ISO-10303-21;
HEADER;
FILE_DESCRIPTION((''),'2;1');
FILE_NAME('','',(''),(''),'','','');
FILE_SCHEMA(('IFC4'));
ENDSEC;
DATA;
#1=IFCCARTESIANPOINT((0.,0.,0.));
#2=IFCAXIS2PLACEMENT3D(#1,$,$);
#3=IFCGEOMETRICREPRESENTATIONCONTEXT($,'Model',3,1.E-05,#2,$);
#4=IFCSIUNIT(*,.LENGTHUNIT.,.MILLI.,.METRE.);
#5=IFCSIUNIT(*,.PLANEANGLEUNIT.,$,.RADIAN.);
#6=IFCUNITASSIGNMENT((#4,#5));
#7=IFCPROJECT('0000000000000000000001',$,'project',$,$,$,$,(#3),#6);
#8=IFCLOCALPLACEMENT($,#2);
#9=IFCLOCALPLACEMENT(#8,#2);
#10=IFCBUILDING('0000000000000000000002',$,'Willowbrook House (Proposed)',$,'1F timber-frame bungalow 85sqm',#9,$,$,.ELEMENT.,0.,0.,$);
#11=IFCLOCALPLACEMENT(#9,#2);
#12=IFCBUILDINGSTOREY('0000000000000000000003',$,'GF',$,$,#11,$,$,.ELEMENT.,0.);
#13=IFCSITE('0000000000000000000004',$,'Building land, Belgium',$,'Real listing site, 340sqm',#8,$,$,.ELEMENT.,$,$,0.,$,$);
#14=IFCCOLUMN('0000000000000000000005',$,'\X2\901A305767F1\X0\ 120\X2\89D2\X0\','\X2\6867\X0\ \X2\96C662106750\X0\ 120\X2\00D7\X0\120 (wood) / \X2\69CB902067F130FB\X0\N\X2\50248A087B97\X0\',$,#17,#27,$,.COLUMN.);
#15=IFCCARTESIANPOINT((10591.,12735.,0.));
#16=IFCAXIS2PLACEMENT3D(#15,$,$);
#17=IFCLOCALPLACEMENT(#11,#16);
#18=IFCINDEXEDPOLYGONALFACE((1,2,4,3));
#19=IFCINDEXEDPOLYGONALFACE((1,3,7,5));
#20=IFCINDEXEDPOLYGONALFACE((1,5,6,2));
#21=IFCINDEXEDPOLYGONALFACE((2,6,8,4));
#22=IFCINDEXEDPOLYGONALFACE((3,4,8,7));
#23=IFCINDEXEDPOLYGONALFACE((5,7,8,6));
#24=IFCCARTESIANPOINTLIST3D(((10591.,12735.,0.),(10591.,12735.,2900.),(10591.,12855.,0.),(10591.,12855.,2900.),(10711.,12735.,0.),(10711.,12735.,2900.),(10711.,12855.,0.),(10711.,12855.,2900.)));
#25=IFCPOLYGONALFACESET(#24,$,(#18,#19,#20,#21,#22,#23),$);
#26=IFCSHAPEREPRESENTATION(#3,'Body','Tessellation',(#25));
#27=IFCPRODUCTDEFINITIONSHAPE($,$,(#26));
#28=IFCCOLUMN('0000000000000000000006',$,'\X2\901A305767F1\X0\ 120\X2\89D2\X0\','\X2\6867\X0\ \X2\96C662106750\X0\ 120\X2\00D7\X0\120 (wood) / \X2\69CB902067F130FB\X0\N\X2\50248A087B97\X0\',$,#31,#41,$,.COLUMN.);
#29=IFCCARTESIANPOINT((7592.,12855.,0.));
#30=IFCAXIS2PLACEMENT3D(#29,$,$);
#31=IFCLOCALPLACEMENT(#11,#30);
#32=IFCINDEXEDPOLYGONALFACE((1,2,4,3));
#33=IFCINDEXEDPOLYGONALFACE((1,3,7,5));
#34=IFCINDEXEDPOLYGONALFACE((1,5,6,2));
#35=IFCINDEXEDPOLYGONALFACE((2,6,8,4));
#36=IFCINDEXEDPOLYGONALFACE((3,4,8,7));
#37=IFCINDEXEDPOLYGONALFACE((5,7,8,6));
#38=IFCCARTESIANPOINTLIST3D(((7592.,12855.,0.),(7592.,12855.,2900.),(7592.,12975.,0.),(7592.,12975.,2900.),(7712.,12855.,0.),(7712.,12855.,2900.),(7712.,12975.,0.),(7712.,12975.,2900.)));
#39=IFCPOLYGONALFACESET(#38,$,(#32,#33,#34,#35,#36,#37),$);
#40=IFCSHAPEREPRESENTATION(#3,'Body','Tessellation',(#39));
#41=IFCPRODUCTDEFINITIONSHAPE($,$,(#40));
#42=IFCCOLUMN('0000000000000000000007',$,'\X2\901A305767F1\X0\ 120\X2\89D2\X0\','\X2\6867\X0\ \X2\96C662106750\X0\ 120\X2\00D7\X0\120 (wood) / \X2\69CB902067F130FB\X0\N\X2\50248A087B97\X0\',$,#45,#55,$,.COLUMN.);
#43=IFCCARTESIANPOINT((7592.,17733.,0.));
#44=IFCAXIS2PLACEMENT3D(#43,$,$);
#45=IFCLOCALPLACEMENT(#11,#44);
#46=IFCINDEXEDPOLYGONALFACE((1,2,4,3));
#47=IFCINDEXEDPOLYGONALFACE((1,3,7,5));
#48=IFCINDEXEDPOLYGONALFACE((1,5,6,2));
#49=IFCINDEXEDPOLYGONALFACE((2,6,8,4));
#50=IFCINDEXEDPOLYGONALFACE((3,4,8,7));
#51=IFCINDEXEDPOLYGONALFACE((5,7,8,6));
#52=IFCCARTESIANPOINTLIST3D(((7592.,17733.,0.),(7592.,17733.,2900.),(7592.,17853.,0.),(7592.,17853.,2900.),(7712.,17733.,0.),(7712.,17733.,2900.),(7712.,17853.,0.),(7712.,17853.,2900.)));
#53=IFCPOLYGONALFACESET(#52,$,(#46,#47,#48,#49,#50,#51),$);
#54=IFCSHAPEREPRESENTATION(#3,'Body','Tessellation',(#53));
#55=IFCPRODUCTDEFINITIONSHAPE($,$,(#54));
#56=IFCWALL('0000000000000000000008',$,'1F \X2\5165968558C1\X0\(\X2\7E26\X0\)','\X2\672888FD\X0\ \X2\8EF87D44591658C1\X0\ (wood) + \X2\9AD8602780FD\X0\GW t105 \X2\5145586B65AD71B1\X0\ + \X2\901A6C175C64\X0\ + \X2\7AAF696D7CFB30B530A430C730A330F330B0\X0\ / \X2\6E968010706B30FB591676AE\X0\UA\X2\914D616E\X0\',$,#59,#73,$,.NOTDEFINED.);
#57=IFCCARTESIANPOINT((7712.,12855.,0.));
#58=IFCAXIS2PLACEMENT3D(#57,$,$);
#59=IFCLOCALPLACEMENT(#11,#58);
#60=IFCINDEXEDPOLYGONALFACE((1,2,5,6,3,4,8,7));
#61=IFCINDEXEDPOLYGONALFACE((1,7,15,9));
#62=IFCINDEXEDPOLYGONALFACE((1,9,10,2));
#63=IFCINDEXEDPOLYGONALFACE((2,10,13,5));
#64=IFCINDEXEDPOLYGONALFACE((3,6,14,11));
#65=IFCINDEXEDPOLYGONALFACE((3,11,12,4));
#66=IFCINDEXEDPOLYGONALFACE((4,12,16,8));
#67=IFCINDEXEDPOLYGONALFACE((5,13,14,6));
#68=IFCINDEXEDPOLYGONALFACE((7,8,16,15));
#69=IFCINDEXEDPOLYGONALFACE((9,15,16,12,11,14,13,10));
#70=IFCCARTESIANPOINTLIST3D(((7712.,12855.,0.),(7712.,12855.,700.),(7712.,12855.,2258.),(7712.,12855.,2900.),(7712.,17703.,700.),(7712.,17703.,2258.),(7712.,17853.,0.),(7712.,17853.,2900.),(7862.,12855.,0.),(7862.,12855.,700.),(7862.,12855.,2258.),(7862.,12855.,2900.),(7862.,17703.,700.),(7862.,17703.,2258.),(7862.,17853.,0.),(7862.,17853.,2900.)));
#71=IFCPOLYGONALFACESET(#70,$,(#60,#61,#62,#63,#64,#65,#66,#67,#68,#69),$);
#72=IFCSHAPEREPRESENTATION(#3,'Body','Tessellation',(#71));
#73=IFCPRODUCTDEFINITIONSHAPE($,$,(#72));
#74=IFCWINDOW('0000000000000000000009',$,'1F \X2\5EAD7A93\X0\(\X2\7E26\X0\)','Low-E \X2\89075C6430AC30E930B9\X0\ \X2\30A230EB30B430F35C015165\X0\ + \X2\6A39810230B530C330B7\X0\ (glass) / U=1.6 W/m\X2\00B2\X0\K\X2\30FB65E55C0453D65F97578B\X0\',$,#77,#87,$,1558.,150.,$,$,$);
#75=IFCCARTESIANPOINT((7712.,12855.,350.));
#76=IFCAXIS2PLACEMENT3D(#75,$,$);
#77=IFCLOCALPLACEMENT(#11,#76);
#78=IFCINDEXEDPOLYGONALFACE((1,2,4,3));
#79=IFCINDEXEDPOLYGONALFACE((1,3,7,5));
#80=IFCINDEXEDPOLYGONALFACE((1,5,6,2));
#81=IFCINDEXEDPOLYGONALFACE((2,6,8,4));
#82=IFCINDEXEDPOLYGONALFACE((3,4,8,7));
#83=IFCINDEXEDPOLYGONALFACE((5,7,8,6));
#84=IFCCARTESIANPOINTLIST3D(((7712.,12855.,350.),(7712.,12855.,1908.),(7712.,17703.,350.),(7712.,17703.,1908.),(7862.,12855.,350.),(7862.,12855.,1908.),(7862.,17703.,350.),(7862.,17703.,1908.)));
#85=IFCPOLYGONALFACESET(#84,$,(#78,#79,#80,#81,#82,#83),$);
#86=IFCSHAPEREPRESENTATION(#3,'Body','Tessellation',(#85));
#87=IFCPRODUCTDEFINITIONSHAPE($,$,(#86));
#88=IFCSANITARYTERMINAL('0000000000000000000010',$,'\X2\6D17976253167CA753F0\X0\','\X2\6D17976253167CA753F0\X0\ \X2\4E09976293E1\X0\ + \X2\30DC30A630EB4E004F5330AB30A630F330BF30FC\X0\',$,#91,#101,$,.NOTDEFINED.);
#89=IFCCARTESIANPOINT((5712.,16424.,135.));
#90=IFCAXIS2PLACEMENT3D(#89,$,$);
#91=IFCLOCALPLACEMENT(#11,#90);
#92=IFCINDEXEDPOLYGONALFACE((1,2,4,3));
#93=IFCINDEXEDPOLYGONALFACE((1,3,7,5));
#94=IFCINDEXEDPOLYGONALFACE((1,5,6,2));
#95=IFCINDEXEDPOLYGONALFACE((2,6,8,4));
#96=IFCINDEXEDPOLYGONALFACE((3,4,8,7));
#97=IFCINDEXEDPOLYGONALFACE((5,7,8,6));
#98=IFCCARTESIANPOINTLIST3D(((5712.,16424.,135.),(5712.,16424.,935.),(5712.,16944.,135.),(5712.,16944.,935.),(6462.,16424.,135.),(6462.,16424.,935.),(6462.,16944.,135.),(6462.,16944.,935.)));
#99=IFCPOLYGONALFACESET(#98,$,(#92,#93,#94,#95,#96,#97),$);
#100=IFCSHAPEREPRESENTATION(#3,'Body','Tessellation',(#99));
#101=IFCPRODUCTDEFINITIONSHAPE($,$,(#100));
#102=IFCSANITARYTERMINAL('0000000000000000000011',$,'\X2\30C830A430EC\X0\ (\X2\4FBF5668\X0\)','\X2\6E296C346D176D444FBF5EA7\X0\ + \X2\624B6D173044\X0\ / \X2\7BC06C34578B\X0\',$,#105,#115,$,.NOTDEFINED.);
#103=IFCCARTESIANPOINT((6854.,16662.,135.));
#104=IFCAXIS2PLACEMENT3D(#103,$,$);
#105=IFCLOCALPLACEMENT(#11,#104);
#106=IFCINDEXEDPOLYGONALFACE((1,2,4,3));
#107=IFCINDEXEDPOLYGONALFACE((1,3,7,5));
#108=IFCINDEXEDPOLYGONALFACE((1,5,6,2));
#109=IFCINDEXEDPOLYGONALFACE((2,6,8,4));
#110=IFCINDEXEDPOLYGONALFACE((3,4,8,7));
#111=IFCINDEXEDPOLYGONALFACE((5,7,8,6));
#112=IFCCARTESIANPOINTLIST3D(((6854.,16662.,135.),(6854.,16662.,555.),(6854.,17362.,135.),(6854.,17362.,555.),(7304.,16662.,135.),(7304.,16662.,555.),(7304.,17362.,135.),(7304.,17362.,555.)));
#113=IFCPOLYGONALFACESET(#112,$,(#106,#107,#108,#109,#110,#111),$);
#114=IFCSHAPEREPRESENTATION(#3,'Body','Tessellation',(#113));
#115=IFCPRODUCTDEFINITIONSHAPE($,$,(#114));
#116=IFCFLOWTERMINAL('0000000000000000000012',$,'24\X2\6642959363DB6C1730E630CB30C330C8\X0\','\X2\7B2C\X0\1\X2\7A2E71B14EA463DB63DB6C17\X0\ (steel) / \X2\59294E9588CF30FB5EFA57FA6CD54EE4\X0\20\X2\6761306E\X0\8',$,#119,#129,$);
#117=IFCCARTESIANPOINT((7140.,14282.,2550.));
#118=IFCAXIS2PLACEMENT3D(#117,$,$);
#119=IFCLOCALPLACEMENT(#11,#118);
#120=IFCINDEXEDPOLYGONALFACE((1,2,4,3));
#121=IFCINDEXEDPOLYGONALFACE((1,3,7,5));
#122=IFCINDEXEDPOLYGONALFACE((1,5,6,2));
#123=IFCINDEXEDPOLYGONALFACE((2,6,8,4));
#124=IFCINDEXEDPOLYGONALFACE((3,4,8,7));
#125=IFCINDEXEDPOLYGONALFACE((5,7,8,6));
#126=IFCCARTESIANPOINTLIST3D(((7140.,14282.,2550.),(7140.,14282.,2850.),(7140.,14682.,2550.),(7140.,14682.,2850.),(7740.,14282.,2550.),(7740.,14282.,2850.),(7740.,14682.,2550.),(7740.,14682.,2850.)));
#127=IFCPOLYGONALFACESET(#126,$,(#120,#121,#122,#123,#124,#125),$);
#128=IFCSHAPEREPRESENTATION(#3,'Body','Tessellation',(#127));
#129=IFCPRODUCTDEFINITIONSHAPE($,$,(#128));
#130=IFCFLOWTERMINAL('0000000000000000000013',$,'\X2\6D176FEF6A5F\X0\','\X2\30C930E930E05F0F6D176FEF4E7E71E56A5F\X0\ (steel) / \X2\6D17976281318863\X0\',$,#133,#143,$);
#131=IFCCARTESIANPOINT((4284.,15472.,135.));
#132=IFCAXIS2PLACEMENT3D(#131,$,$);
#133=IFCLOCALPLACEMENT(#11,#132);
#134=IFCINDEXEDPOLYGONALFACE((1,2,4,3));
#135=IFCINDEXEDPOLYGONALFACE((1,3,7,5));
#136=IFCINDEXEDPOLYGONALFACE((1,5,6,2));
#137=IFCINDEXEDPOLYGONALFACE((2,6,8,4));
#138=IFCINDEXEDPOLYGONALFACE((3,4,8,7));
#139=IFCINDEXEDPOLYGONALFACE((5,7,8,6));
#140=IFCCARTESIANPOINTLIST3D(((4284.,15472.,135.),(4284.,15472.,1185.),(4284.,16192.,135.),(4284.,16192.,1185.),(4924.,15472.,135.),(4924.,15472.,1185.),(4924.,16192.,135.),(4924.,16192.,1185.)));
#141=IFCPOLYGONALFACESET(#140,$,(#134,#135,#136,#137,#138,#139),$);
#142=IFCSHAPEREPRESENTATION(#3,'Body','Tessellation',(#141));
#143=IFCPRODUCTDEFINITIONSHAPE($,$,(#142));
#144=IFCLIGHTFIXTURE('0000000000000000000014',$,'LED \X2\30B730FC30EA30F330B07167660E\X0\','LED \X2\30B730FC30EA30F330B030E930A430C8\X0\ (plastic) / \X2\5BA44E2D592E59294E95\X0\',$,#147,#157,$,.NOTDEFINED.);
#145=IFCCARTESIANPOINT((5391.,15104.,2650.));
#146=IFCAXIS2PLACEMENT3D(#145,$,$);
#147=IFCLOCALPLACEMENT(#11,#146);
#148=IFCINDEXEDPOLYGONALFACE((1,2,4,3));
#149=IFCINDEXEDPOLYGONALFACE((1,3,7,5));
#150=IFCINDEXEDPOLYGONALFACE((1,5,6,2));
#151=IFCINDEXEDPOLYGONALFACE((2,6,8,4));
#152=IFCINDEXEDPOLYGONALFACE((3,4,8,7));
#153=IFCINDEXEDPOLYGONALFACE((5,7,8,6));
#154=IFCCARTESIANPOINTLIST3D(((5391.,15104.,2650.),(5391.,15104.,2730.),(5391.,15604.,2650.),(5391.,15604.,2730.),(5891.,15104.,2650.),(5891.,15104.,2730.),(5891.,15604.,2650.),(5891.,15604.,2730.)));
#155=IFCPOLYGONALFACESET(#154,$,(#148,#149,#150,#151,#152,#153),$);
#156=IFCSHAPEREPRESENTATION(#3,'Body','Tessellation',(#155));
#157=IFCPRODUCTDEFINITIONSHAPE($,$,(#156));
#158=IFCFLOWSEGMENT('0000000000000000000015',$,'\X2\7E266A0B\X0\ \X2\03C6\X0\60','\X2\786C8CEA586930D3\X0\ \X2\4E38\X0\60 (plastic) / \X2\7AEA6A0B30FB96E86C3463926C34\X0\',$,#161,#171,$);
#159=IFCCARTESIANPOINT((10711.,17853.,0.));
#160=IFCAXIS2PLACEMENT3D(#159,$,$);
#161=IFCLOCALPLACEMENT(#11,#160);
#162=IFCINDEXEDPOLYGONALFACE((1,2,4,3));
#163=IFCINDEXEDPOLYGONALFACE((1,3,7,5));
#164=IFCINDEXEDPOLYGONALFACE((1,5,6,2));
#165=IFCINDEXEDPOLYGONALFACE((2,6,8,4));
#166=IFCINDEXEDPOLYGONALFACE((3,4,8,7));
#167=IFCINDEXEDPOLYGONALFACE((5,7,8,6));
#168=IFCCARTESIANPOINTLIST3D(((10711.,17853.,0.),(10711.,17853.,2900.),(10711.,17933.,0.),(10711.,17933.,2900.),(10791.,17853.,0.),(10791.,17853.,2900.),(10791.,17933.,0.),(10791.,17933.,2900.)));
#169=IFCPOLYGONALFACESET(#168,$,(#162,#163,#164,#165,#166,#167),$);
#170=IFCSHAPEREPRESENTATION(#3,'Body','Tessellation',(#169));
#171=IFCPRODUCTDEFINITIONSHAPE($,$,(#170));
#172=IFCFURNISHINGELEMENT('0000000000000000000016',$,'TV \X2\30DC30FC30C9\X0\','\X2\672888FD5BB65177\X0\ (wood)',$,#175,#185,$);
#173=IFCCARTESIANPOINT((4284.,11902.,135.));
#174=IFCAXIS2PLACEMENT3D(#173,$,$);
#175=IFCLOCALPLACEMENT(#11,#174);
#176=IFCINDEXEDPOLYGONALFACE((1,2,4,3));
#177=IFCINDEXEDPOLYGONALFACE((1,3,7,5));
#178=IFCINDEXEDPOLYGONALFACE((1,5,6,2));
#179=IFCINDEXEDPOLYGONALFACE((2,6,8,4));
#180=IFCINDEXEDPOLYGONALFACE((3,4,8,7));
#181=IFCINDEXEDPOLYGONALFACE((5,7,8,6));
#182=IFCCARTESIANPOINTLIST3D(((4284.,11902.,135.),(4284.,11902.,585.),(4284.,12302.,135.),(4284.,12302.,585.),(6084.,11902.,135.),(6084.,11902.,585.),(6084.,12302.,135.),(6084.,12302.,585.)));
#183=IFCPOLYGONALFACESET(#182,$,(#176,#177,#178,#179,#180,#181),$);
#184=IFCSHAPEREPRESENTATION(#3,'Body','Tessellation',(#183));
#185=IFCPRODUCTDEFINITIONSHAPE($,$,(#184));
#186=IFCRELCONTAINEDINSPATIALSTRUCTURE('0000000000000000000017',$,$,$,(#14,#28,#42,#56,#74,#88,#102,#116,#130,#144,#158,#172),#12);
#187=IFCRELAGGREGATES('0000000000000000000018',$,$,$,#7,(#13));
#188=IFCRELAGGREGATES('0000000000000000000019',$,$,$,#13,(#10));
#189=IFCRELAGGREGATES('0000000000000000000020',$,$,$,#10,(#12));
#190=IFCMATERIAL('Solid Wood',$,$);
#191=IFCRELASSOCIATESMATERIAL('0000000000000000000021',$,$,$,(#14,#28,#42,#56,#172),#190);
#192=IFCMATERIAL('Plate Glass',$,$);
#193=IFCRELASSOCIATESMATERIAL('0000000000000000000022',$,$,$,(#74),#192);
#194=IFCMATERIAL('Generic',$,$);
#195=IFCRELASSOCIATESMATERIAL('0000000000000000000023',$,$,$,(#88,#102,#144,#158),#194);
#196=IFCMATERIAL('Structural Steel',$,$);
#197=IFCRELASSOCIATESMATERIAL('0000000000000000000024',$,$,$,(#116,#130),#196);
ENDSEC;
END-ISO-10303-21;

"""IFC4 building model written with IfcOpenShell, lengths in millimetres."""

from ifc_helpers import new_model, si_unit, frame, frame_2d, origin, place, context, project, spatial, rectangle, extrude, material, element, fill, save


model = new_model("IFC4")

# Units and contexts
model_context = context("Model", 3, precision=1e-05, world=origin())
ifc_project = project(units=[si_unit("LENGTHUNIT", "METRE", prefix="MILLI"), si_unit("PLANEANGLEUNIT", "RADIAN")], contexts=[model_context])

# Site, building, storey
site_placement = place(None, origin())
site = spatial("IfcSite", under=ifc_project, at=site_placement, Name="Building land, Belgium", ObjectType="Real listing site, 340sqm", CompositionType="ELEMENT", RefElevation=0.0)
building_placement = place(site_placement, origin())
building = spatial("IfcBuilding", under=site, at=building_placement, Name="Willowbrook House (Proposed)", ObjectType="1F timber-frame bungalow 85sqm", CompositionType="ELEMENT", ElevationOfRefHeight=0.0, ElevationOfTerrain=0.0)
storey_placement = place(building_placement, origin())
storey = spatial("IfcBuildingStorey", under=building, at=storey_placement, Name="GF", CompositionType="ELEMENT", Elevation=0.0)

# Columns
ifc_material_1 = material(Name="Solid Wood")
column_1_placement = place(storey_placement, frame((10591.0, 12735.0, 0.0)))
element("IfcColumn", 1, at=column_1_placement, inside=storey, material=ifc_material_1, Name="通し柱 120角", Description="桧 集成材 120×120 (wood) / 構造柱・N値計算", PredefinedType="COLUMN", context=model_context, shape_type="SweptSolid", body=[
    extrude(rectangle(XDim=120.0, YDim=120.0, at=frame_2d((60.0, 60.0))), frame((10591.0, 12735.0, 0.0)), (0.0, 0.0, 1.0), 2900.0),
])
column_2_placement = place(storey_placement, frame((7592.0, 12855.0, 0.0)))
element("IfcColumn", 2, at=column_2_placement, inside=storey, material=ifc_material_1, Name="通し柱 120角", Description="桧 集成材 120×120 (wood) / 構造柱・N値計算", PredefinedType="COLUMN", context=model_context, shape_type="SweptSolid", body=[
    extrude(rectangle(XDim=120.0, YDim=120.0, at=frame_2d((60.0, 60.0))), frame((7592.0, 12855.0, 0.0)), (0.0, 0.0, 1.0), 2900.0),
])
column_3_placement = place(storey_placement, frame((7592.0, 17733.0, 0.0)))
element("IfcColumn", 3, at=column_3_placement, inside=storey, material=ifc_material_1, Name="通し柱 120角", Description="桧 集成材 120×120 (wood) / 構造柱・N値計算", PredefinedType="COLUMN", context=model_context, shape_type="SweptSolid", body=[
    extrude(rectangle(XDim=120.0, YDim=120.0, at=frame_2d((60.0, 60.0))), frame((7592.0, 17733.0, 0.0)), (0.0, 0.0, 1.0), 2900.0),
])

# Wall, opening, window
wall_1_placement = place(storey_placement, frame((7712.0, 12855.0, 0.0)))
wall_1 = element("IfcWall", 4, at=wall_1_placement, inside=storey, material=ifc_material_1, Name="1F 入隅壁(縦)", Description="木製 軸組外壁 (wood) + 高性能GW t105 充填断熱 + 通気層 + 窯業系サイディング / 準耐火・外皮UA配慮", PredefinedType="NOTDEFINED", context=model_context, shape_type="SweptSolid", body=[
    extrude(rectangle(XDim=150.0, YDim=4998.0, at=frame_2d((75.0, 2499.0))), frame((7712.0, 12855.0, 0.0)), (0.0, 0.0, 1.0), 2900.0),
])
opening_placement = place(storey_placement, frame((7712.0, 12855.0, 350.0)))
opening = element("IfcOpeningElement", 5, at=opening_placement, cuts=wall_1, PredefinedType="NOTDEFINED", context=model_context, shape_type="SweptSolid", body=[
    extrude(rectangle(XDim=150.0, YDim=4848.0, at=frame_2d((75.0, 2424.0))), frame((7712.0, 12855.0, 350.0)), (0.0, 0.0, 1.0), 1558.0),
])
ifc_material_2 = material(Name="Plate Glass")
window_placement = place(storey_placement, frame((7712.0, 12855.0, 350.0)))
window = element("IfcWindow", 6, at=window_placement, inside=storey, material=ifc_material_2, Name="1F 庭窓(縦)", Description="Low-E 複層ガラス アルゴン封入 + 樹脂サッシ (glass) / U=1.6 W/m²K・日射取得型", OverallHeight=1558.0, OverallWidth=150.0, context=model_context, shape_type="SweptSolid", body=[
    extrude(rectangle(XDim=150.0, YDim=4848.0, at=frame_2d((75.0, 2424.0))), frame((7712.0, 12855.0, 350.0)), (0.0, 0.0, 1.0), 1558.0),
])
fill(opening, window)

# Sanitary terminals
ifc_material_3 = material(Name="Generic")
sanitary_terminal_1_placement = place(storey_placement, frame((5712.0, 16424.0, 135.0)))
element("IfcSanitaryTerminal", 7, at=sanitary_terminal_1_placement, inside=storey, material=ifc_material_3, Name="洗面化粧台", Description="洗面化粧台 三面鏡 + ボウル一体カウンター", PredefinedType="NOTDEFINED", context=model_context, shape_type="SweptSolid", body=[
    extrude(rectangle(XDim=750.0, YDim=520.0, at=frame_2d((375.0, 260.0))), frame((5712.0, 16424.0, 135.0)), (0.0, 0.0, 1.0), 800.0),
])
sanitary_terminal_2_placement = place(storey_placement, frame((6854.0, 16662.0, 135.0)))
element("IfcSanitaryTerminal", 8, at=sanitary_terminal_2_placement, inside=storey, material=ifc_material_3, Name="トイレ (便器)", Description="温水洗浄便座 + 手洗い / 節水型", PredefinedType="NOTDEFINED", context=model_context, shape_type="SweptSolid", body=[
    extrude(rectangle(XDim=450.0, YDim=700.0, at=frame_2d((225.0, 350.0))), frame((6854.0, 16662.0, 135.0)), (0.0, 0.0, 1.0), 420.0),
])

# Flow terminals
ifc_material_4 = material(Name="Structural Steel")
flow_terminal_1_placement = place(storey_placement, frame((7140.0, 14282.0, 2550.0)))
element("IfcFlowTerminal", 9, at=flow_terminal_1_placement, inside=storey, material=ifc_material_4, Name="24時間換気ユニット", Description="第1種熱交換換気 (steel) / 天井裏・建基法令20条の8", context=model_context, shape_type="SweptSolid", body=[
    extrude(rectangle(XDim=600.0, YDim=400.0, at=frame_2d((300.0, 200.0))), frame((7140.0, 14282.0, 2550.0)), (0.0, 0.0, 1.0), 300.0),
])
flow_terminal_2_placement = place(storey_placement, frame((4284.0, 15472.0, 135.0)))
element("IfcFlowTerminal", 10, at=flow_terminal_2_placement, inside=storey, material=ifc_material_4, Name="洗濯機", Description="ドラム式洗濯乾燥機 (steel) / 洗面脱衣", context=model_context, shape_type="SweptSolid", body=[
    extrude(rectangle(XDim=640.0, YDim=720.0, at=frame_2d((320.0, 360.0))), frame((4284.0, 15472.0, 135.0)), (0.0, 0.0, 1.0), 1050.0),
])

# Light fixture
light_fixture_placement = place(storey_placement, frame((5391.0, 15104.0, 2650.0)))
element("IfcLightFixture", 11, at=light_fixture_placement, inside=storey, material=ifc_material_3, Name="LED シーリング照明", Description="LED シーリングライト (plastic) / 室中央天井", PredefinedType="NOTDEFINED", context=model_context, shape_type="SweptSolid", body=[
    extrude(rectangle(XDim=500.0, YDim=500.0, at=frame_2d((250.0, 250.0))), frame((5391.0, 15104.0, 2650.0)), (0.0, 0.0, 1.0), 80.0),
])

# Flow segment
flow_segment_placement = place(storey_placement, frame((10711.0, 17853.0, 0.0)))
element("IfcFlowSegment", 12, at=flow_segment_placement, inside=storey, material=ifc_material_3, Name="縦樋 φ60", Description="硬質塩ビ 丸60 (plastic) / 竪樋・雨水排水", context=model_context, shape_type="SweptSolid", body=[
    extrude(rectangle(XDim=80.0, YDim=80.0, at=frame_2d((40.0, 40.0))), frame((10711.0, 17853.0, 0.0)), (0.0, 0.0, 1.0), 2900.0),
])

# Furnishing element
furnishing_placement = place(storey_placement, frame((4284.0, 11902.0, 135.0)))
element("IfcFurnishingElement", 13, at=furnishing_placement, inside=storey, material=ifc_material_1, Name="TV ボード", Description="木製家具 (wood)", context=model_context, shape_type="SweptSolid", body=[
    extrude(rectangle(XDim=1800.0, YDim=400.0, at=frame_2d((900.0, 200.0))), frame((4284.0, 11902.0, 135.0)), (0.0, 0.0, 1.0), 450.0),
])

save(model, "model.ifc")
